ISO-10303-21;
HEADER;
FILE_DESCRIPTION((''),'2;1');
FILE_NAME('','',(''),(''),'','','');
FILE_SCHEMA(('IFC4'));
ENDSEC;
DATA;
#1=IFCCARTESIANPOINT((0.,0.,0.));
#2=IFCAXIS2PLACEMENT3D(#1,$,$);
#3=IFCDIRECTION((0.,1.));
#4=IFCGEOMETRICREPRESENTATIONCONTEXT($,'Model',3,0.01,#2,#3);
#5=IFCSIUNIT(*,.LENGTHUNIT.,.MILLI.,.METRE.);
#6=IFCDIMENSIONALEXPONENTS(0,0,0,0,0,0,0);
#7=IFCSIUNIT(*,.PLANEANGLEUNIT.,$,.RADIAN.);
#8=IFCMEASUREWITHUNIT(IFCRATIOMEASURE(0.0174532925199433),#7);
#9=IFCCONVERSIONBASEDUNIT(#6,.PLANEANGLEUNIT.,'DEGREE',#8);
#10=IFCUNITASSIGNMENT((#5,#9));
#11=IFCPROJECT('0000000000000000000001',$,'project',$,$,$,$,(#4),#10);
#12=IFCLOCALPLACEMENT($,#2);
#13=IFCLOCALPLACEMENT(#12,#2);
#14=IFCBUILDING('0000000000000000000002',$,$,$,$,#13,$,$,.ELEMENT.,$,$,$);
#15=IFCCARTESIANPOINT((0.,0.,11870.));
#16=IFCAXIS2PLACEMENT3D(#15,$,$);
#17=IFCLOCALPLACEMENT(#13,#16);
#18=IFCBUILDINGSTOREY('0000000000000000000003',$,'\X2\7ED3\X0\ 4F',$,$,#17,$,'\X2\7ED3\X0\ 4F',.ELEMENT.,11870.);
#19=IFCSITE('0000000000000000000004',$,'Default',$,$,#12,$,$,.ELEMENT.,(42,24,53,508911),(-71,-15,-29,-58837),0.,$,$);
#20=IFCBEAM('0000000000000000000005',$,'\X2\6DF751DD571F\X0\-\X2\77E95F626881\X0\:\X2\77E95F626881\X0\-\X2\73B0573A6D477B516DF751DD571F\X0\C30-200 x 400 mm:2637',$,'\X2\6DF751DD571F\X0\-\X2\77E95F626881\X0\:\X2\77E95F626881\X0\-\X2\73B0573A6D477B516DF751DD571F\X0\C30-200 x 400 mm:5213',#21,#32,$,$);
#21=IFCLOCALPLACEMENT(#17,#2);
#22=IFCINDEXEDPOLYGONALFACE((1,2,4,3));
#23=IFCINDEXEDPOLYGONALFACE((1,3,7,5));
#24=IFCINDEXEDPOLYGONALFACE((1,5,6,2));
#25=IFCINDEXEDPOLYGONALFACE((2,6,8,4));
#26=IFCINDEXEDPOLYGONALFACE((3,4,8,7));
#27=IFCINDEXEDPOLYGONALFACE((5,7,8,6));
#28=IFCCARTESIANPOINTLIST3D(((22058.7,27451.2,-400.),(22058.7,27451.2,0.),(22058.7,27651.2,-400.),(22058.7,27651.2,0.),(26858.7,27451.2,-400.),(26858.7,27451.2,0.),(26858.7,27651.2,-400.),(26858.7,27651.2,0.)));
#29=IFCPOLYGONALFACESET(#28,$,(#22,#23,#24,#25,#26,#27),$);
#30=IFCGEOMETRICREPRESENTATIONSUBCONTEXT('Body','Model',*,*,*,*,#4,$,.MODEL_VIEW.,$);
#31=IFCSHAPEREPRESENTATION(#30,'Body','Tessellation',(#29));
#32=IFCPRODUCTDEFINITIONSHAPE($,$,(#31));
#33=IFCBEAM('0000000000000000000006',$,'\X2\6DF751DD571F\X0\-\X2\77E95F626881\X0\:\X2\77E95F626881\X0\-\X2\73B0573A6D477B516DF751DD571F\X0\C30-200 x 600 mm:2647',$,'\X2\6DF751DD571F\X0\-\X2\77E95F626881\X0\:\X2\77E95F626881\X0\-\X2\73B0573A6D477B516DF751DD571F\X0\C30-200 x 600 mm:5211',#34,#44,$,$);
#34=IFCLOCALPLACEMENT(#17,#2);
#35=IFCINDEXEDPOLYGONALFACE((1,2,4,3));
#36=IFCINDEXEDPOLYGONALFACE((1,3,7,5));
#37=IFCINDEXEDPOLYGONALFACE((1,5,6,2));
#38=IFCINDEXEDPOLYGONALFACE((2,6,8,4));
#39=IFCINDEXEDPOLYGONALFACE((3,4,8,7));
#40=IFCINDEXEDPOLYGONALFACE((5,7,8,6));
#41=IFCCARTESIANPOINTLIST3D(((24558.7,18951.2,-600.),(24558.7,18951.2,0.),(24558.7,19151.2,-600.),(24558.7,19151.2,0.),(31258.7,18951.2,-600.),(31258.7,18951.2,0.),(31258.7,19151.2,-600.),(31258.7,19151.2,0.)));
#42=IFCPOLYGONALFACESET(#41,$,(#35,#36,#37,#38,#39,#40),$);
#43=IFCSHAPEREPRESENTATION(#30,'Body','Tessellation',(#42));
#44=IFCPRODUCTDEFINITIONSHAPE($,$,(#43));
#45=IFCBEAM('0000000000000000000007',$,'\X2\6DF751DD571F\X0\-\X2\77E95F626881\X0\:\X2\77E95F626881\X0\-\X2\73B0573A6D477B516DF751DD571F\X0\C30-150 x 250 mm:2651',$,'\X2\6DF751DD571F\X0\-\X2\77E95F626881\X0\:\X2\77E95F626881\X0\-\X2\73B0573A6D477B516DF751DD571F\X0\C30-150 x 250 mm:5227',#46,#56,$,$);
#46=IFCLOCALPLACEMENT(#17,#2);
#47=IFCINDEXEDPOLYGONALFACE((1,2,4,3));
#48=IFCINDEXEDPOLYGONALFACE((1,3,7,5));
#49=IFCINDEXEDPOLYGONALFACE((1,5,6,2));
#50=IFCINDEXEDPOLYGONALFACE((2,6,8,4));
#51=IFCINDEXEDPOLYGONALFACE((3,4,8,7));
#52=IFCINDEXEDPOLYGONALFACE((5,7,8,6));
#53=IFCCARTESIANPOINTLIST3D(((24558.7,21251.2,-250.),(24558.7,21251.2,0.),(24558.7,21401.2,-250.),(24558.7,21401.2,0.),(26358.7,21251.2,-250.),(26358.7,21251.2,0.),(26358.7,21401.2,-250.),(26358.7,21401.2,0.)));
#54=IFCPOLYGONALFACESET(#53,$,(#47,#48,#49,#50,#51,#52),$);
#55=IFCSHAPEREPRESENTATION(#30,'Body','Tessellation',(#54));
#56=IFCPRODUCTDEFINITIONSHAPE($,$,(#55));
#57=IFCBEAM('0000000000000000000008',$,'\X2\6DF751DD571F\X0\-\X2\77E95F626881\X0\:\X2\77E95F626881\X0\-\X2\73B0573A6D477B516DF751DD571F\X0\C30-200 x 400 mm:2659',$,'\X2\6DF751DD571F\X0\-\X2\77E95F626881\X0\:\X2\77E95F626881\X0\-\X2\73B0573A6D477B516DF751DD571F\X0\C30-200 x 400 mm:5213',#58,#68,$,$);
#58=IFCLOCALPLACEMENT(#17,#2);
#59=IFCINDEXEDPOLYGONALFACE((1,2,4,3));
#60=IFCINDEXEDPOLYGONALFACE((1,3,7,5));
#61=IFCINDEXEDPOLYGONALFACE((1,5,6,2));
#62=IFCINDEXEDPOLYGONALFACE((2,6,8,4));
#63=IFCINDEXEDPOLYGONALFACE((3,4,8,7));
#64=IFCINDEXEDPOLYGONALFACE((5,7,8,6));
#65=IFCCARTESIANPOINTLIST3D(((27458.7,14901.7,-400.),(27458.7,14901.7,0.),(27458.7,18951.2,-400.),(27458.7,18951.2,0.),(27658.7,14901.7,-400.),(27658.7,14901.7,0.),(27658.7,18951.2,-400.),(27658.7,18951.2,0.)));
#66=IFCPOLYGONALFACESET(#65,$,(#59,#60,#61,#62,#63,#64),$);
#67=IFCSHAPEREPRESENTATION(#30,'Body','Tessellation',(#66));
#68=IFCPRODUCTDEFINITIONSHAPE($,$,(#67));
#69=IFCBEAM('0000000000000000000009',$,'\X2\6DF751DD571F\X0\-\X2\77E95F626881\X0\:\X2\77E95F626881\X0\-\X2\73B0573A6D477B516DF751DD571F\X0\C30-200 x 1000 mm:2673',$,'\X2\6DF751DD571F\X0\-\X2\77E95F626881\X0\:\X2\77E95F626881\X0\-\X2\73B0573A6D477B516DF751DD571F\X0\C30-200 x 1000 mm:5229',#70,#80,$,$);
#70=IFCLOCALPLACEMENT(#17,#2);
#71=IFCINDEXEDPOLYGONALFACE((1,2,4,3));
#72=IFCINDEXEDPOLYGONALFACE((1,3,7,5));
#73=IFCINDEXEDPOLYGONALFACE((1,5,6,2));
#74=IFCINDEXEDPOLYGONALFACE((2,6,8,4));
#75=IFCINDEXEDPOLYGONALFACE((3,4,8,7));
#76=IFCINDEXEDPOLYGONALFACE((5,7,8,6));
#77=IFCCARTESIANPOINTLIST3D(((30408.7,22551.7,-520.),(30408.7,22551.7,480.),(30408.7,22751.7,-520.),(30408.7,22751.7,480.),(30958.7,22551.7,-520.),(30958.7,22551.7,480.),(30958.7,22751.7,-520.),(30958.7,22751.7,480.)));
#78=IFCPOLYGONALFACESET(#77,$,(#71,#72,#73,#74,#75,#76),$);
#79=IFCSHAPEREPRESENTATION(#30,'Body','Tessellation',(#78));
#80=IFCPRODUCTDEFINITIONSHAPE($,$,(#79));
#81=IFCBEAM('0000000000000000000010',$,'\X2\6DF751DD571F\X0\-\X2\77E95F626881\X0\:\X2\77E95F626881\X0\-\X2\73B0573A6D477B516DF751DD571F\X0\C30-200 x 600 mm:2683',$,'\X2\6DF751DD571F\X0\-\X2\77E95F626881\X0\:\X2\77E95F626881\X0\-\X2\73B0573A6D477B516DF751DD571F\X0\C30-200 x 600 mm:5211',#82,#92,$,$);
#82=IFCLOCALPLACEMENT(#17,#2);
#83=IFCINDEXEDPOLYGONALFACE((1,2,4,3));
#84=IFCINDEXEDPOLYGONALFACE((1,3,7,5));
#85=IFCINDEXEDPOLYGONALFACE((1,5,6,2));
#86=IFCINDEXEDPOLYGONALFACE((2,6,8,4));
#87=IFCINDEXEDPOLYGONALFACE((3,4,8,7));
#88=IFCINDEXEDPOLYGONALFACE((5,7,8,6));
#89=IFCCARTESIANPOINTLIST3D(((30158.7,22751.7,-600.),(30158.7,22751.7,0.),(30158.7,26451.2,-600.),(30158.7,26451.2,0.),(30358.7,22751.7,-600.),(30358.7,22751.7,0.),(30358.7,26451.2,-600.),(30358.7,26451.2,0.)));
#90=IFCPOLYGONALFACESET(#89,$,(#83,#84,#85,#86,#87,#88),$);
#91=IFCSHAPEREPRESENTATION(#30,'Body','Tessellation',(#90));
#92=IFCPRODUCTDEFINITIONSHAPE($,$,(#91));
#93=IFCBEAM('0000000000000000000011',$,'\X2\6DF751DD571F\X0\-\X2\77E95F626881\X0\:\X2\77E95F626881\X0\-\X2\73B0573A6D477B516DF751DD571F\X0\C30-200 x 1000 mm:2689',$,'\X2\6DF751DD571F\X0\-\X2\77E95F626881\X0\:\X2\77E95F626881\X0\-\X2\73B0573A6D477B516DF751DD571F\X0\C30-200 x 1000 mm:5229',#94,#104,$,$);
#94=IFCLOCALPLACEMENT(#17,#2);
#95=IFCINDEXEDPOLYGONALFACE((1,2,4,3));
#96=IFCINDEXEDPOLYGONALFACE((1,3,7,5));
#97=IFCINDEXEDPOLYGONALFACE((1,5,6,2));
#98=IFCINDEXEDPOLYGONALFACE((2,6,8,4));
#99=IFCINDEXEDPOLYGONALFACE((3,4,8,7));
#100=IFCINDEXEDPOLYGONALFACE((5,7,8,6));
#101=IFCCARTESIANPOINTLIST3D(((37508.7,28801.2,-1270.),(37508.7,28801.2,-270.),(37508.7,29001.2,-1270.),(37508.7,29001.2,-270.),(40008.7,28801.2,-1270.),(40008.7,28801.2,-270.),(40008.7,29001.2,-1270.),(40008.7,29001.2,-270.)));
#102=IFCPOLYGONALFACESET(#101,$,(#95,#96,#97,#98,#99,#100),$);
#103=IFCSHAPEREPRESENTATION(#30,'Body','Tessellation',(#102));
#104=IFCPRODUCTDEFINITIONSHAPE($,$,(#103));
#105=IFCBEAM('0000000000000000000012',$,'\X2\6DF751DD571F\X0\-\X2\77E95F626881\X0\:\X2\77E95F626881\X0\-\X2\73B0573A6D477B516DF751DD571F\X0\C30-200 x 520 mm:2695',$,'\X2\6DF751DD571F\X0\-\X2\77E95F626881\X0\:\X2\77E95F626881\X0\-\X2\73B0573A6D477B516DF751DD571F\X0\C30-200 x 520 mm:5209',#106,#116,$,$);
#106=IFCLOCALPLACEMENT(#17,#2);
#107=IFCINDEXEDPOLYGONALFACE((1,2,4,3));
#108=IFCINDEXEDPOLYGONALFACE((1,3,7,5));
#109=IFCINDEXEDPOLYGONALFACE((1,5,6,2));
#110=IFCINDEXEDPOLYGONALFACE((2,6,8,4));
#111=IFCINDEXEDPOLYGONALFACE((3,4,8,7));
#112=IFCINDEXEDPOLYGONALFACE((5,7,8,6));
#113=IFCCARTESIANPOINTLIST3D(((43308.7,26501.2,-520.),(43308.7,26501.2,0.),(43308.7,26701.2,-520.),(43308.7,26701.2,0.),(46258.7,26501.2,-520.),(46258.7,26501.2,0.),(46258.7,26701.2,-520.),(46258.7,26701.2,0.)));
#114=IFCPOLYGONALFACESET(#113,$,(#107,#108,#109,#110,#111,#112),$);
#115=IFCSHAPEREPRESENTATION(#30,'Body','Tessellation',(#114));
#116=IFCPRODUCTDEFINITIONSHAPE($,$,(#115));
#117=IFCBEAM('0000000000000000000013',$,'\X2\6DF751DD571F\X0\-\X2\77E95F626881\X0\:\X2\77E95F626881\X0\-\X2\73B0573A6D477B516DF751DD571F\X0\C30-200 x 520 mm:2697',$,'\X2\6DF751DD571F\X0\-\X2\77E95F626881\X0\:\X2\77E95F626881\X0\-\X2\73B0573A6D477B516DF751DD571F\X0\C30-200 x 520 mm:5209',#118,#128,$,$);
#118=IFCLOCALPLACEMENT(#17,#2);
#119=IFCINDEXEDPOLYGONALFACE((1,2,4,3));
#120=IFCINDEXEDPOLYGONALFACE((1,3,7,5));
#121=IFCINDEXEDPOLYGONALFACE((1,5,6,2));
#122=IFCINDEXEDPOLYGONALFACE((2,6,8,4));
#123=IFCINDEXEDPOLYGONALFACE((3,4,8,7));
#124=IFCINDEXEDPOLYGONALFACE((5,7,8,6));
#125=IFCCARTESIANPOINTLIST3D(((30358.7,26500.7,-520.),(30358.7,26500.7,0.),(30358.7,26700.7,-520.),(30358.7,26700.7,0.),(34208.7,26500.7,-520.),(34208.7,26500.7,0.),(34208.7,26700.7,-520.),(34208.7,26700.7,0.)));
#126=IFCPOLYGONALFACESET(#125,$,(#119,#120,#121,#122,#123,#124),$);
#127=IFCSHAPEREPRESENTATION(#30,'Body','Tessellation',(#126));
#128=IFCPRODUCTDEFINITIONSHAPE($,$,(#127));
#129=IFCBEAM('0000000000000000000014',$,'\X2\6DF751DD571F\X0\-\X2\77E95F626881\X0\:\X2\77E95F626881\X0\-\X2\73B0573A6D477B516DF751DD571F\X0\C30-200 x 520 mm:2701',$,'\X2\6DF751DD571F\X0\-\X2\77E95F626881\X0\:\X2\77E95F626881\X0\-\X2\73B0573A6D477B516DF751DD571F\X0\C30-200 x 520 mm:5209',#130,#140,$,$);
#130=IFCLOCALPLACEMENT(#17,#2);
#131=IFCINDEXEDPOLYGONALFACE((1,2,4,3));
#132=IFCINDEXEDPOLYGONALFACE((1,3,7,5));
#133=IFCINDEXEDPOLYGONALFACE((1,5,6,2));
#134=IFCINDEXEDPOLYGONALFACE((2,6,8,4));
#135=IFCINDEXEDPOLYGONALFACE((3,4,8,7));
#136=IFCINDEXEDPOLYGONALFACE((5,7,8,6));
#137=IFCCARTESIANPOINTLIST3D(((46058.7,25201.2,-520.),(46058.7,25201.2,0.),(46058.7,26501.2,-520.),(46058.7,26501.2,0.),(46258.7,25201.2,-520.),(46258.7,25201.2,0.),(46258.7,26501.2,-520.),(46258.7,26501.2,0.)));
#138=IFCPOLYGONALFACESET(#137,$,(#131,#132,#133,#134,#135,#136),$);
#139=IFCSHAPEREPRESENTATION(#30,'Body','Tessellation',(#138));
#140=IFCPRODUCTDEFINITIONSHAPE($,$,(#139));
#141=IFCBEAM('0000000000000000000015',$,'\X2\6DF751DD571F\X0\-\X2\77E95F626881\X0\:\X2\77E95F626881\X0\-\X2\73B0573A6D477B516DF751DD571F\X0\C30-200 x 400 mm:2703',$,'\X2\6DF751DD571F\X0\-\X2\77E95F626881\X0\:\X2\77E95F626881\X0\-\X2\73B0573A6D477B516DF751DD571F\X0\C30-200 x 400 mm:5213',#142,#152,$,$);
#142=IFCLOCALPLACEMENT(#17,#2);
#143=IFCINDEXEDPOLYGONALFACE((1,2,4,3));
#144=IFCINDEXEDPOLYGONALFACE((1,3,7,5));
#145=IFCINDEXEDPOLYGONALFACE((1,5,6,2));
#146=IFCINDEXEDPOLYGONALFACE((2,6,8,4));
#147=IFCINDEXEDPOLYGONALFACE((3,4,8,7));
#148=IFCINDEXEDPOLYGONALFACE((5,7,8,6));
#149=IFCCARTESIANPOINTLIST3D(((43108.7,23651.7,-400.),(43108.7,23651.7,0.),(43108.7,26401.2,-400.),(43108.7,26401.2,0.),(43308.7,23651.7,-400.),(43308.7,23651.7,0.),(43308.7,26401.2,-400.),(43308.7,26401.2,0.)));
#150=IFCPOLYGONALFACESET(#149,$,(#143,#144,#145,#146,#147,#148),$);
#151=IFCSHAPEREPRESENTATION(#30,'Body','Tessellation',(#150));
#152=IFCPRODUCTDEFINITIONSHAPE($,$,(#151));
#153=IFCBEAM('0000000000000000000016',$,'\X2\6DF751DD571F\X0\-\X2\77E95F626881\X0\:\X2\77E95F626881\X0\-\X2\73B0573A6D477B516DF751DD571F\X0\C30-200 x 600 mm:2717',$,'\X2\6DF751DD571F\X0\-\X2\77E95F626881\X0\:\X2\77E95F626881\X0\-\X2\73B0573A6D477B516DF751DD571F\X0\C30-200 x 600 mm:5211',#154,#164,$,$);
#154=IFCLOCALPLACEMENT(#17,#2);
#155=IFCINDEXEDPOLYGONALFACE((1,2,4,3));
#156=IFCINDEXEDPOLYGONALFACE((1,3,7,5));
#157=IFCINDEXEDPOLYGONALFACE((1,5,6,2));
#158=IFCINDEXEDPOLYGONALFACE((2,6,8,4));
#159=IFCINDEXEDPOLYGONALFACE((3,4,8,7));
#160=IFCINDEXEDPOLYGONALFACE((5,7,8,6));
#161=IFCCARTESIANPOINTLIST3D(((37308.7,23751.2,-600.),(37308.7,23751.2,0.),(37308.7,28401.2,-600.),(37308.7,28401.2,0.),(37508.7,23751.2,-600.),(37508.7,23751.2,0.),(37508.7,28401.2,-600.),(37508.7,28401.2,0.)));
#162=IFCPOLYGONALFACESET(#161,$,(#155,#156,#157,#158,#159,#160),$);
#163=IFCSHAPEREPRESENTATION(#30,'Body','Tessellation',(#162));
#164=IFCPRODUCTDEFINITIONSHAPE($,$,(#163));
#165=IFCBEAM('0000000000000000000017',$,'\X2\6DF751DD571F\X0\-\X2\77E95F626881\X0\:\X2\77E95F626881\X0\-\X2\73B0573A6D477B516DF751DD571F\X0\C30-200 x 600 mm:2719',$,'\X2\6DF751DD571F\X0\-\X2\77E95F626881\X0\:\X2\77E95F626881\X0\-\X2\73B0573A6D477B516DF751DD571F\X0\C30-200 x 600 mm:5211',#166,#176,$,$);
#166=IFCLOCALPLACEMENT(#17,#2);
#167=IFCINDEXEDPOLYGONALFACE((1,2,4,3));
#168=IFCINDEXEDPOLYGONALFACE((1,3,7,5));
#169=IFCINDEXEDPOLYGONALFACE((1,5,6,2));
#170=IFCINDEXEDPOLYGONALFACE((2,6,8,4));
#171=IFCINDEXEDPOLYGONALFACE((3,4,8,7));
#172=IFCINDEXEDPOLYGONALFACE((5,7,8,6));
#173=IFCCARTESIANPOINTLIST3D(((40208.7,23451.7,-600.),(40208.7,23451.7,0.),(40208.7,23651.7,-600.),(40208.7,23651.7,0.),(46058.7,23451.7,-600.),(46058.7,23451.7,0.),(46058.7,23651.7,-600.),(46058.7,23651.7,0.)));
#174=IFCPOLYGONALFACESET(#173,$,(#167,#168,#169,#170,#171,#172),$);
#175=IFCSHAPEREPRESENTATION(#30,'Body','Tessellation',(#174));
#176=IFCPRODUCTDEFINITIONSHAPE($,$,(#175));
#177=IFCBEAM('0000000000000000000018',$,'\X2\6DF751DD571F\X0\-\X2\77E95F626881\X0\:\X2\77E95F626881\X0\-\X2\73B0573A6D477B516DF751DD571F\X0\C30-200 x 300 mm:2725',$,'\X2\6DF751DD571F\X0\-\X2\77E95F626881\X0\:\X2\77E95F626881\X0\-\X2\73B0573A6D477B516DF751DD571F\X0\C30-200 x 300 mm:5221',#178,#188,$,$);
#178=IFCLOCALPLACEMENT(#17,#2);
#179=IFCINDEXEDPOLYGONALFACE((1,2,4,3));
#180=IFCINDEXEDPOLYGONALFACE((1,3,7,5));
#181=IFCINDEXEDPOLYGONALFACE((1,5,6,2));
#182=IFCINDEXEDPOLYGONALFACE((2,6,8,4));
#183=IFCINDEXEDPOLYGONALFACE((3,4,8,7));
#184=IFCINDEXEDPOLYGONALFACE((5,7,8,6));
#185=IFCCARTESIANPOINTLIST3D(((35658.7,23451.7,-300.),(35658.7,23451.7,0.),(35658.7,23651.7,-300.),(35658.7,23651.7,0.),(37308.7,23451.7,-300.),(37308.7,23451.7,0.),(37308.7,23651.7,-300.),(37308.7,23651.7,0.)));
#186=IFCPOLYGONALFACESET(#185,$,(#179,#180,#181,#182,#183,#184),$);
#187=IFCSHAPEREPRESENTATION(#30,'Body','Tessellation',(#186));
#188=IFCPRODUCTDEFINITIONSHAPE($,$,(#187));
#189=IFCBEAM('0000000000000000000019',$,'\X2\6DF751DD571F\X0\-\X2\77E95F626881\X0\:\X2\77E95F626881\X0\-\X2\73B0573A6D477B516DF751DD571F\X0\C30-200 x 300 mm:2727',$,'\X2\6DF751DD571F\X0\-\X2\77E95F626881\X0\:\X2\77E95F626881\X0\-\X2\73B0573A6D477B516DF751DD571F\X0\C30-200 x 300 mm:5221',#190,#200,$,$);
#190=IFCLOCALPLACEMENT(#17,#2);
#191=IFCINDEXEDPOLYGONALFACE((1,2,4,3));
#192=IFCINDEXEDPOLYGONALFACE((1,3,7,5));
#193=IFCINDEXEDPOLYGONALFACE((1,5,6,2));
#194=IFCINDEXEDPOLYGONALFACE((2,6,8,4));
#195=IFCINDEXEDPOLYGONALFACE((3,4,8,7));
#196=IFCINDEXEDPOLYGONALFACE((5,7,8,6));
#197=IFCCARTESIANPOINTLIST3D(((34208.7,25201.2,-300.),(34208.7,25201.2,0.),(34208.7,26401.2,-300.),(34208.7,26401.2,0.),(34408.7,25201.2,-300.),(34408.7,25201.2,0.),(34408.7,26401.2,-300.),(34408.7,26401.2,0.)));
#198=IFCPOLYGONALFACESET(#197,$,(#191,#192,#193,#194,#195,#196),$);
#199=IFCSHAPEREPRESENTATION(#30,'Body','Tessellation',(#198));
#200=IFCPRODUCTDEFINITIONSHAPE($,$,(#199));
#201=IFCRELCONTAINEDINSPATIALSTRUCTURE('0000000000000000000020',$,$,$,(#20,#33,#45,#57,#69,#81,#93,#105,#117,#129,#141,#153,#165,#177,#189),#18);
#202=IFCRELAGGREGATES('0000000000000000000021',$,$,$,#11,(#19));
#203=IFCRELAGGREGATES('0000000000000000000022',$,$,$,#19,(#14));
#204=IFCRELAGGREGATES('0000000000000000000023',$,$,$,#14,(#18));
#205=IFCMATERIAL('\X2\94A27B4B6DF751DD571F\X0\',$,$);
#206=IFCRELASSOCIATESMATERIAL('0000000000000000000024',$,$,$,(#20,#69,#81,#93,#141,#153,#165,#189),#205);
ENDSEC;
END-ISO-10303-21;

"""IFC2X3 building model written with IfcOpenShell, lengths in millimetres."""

from ifc_helpers import new_model, entity, si_unit, converted_unit, direction, frame, frame_2d, origin, origin_2d_with_axis, place, context, subcontext, project, spatial, rectangle, extrude, material, element, save


model = new_model("IFC2X3")

# Units and contexts
model_context = context("Model", 3, precision=0.01, world=origin(), true_north=direction((0.0, 1.0)))
body_context = subcontext(model_context, "Body", "Model", "MODEL_VIEW")
ifc_project = project(units=[si_unit("LENGTHUNIT", "METRE", prefix="MILLI"), converted_unit("PLANEANGLEUNIT", "DEGREE", entity("IfcRatioMeasure", 0.0174532925199433), si_unit("PLANEANGLEUNIT", "RADIAN"), dimensions=[0, 0, 0, 0, 0, 0, 0])], contexts=[model_context])

# Site, building, storey
site_placement = place(None, origin())
site = spatial("IfcSite", under=ifc_project, at=site_placement, Name="Default", CompositionType="ELEMENT", RefLatitude=(42, 24, 53, 508911), RefLongitude=(-71, -15, -29, -58837), RefElevation=0.0)
building_placement = place(site_placement, origin())
building = spatial("IfcBuilding", under=site, at=building_placement, CompositionType="ELEMENT")
storey_placement = place(building_placement, frame((0.0, 0.0, 11870.0)))
storey = spatial("IfcBuildingStorey", under=building, at=storey_placement, Name="结 4F", LongName="结 4F", CompositionType="ELEMENT", Elevation=11870.0)

# Beams
ifc_material = material(Name="钢筋混凝土")
beam_1_placement = place(storey_placement, frame((26958.7, 27551.2, 0.0), z_axis=(0.0, 0.0, 1.0), x_axis=(-1.0, 0.0, 0.0)))
element("IfcBeam", 1, at=beam_1_placement, inside=storey, material=ifc_material, Name="混凝土-矩形梁:矩形梁-现场浇筑混凝土C30-200 x 400 mm:2637", ObjectType="混凝土-矩形梁:矩形梁-现场浇筑混凝土C30-200 x 400 mm:5213", context=body_context, shape_type="SweptSolid", body=[
    extrude(rectangle(XDim=400.0, YDim=200.0, at=frame_2d((0.0, 0.0), x_axis=(1.0, 0.0))), frame((100.0, 0.0, -200.0), z_axis=(1.0, 0.0, 0.0), x_axis=(0.0, 0.0, -1.0)), (0.0, 0.0, 1.0), 4800.0),
])
beam_2_placement = place(storey_placement, frame((31358.7, 19051.2, 0.0), z_axis=(0.0, 0.0, 1.0), x_axis=(-1.0, 0.0, 0.0)))
element("IfcBeam", 2, at=beam_2_placement, inside=storey, Name="混凝土-矩形梁:矩形梁-现场浇筑混凝土C30-200 x 600 mm:2647", ObjectType="混凝土-矩形梁:矩形梁-现场浇筑混凝土C30-200 x 600 mm:5211", context=body_context, shape_type="SweptSolid", body=[
    extrude(rectangle(XDim=600.0, YDim=200.0, at=frame_2d((0.0, 0.0), x_axis=(1.0, 0.0))), frame((100.0, 0.0, -300.0), z_axis=(1.0, 0.0, 0.0), x_axis=(0.0, 0.0, -1.0)), (0.0, 0.0, 1.0), 6700.0),
])
beam_3_placement = place(storey_placement, frame((26433.7, 21326.2, 0.0), z_axis=(0.0, 0.0, 1.0), x_axis=(-1.0, 0.0, 0.0)))
element("IfcBeam", 3, at=beam_3_placement, inside=storey, Name="混凝土-矩形梁:矩形梁-现场浇筑混凝土C30-150 x 250 mm:2651", ObjectType="混凝土-矩形梁:矩形梁-现场浇筑混凝土C30-150 x 250 mm:5227", context=body_context, shape_type="SweptSolid", body=[
    extrude(rectangle(XDim=250.0, YDim=150.0, at=frame_2d((0.0, 0.0), x_axis=(1.0, 0.0))), frame((75.0, 0.0, -125.0), z_axis=(1.0, 0.0, 0.0), x_axis=(0.0, 0.0, -1.0)), (0.0, 0.0, 1.0), 1800.0),
])
beam_4_placement = place(storey_placement, frame((27558.7, 14801.7, 0.0), z_axis=(0.0, 0.0, 1.0), x_axis=(0.0, 1.0, 0.0)))
element("IfcBeam", 4, at=beam_4_placement, inside=storey, Name="混凝土-矩形梁:矩形梁-现场浇筑混凝土C30-200 x 400 mm:2659", ObjectType="混凝土-矩形梁:矩形梁-现场浇筑混凝土C30-200 x 400 mm:5213", context=body_context, shape_type="SweptSolid", body=[
    extrude(rectangle(XDim=400.0, YDim=200.0, at=frame_2d((0.0, 0.0), x_axis=(1.0, 0.0))), frame((100.0, 0.0, -200.0), z_axis=(1.0, 0.0, 0.0), x_axis=(0.0, 0.0, -1.0)), (0.0, 0.0, 1.0), 4049.5),
])
beam_5_placement = place(storey_placement, frame((31358.7, 22651.7, 480.0), z_axis=(0.0, 0.0, 1.0), x_axis=(-1.0, 0.0, 0.0)))
element("IfcBeam", 5, at=beam_5_placement, inside=storey, material=ifc_material, Name="混凝土-矩形梁:矩形梁-现场浇筑混凝土C30-200 x 1000 mm:2673", ObjectType="混凝土-矩形梁:矩形梁-现场浇筑混凝土C30-200 x 1000 mm:5229", context=body_context, shape_type="SweptSolid", body=[
    extrude(rectangle(XDim=1000.0, YDim=200.0, at=frame_2d((0.0, 0.0), x_axis=(1.0, 0.0))), frame((400.0, 0.0, -500.0), z_axis=(1.0, 0.0, 0.0), x_axis=(0.0, 0.0, -1.0)), (0.0, 0.0, 1.0), 550.0),
])
beam_6_placement = place(storey_placement, frame((30258.7, 22651.7, 0.0), z_axis=(0.0, 0.0, 1.0), x_axis=(0.0, 1.0, 0.0)))
element("IfcBeam", 6, at=beam_6_placement, inside=storey, material=ifc_material, Name="混凝土-矩形梁:矩形梁-现场浇筑混凝土C30-200 x 600 mm:2683", ObjectType="混凝土-矩形梁:矩形梁-现场浇筑混凝土C30-200 x 600 mm:5211", context=body_context, shape_type="SweptSolid", body=[
    extrude(rectangle(XDim=600.0, YDim=200.0, at=frame_2d((0.0, 0.0), x_axis=(1.0, 0.0))), frame((100.0, 0.0, -300.0), z_axis=(1.0, 0.0, 0.0), x_axis=(0.0, 0.0, -1.0)), (0.0, 0.0, 1.0), 3699.5),
])
beam_7_placement = place(storey_placement, frame((36458.7, 28901.2, -270.0)))
element("IfcBeam", 7, at=beam_7_placement, inside=storey, material=ifc_material, Name="混凝土-矩形梁:矩形梁-现场浇筑混凝土C30-200 x 1000 mm:2689", ObjectType="混凝土-矩形梁:矩形梁-现场浇筑混凝土C30-200 x 1000 mm:5229", context=body_context, shape_type="SweptSolid", body=[
    extrude(rectangle(XDim=1000.0, YDim=200.0, at=frame_2d((0.0, 0.0), x_axis=(1.0, 0.0))), frame((1050.0, 0.0, -500.0), z_axis=(1.0, 0.0, 0.0), x_axis=(0.0, 0.0, -1.0)), (0.0, 0.0, 1.0), 2500.0),
])
beam_8_placement = place(storey_placement, frame((43208.7, 26601.2, 0.0)))
element("IfcBeam", 8, at=beam_8_placement, inside=storey, Name="混凝土-矩形梁:矩形梁-现场浇筑混凝土C30-200 x 520 mm:2695", ObjectType="混凝土-矩形梁:矩形梁-现场浇筑混凝土C30-200 x 520 mm:5209", context=body_context, shape_type="SweptSolid", body=[
    extrude(rectangle(XDim=520.0, YDim=200.0, at=frame_2d((0.0, 0.0), x_axis=(1.0, 0.0))), frame((100.0, 0.0, -260.0), z_axis=(1.0, 0.0, 0.0), x_axis=(0.0, 0.0, -1.0)), (0.0, 0.0, 1.0), 2950.0),
])
beam_9_placement = place(storey_placement, frame((34308.7, 26600.7, 0.0), z_axis=(0.0, 0.0, 1.0), x_axis=(-1.0, 0.0, 0.0)))
element("IfcBeam", 9, at=beam_9_placement, inside=storey, Name="混凝土-矩形梁:矩形梁-现场浇筑混凝土C30-200 x 520 mm:2697", ObjectType="混凝土-矩形梁:矩形梁-现场浇筑混凝土C30-200 x 520 mm:5209", context=body_context, shape_type="SweptSolid", body=[
    extrude(rectangle(XDim=520.0, YDim=200.0, at=frame_2d((0.0, 0.0), x_axis=(1.0, 0.0))), frame((100.0, 0.0, -260.0), z_axis=(1.0, 0.0, 0.0), x_axis=(0.0, 0.0, -1.0)), (0.0, 0.0, 1.0), 3850.0),
])
beam_10_placement = place(storey_placement, frame((46158.7, 26601.2, 0.0), z_axis=(0.0, 0.0, 1.0), x_axis=(0.0, -1.0, 0.0)))
element("IfcBeam", 10, at=beam_10_placement, inside=storey, Name="混凝土-矩形梁:矩形梁-现场浇筑混凝土C30-200 x 520 mm:2701", ObjectType="混凝土-矩形梁:矩形梁-现场浇筑混凝土C30-200 x 520 mm:5209", context=body_context, shape_type="SweptSolid", body=[
    extrude(rectangle(XDim=520.0, YDim=200.0, at=frame_2d((0.0, 0.0), x_axis=(1.0, 0.0))), frame((100.0, 0.0, -260.0), z_axis=(1.0, 0.0, 0.0), x_axis=(0.0, 0.0, -1.0)), (0.0, 0.0, 1.0), 1300.0),
])
beam_11_placement = place(storey_placement, frame((43208.7, 23551.7, 0.0), z_axis=(0.0, 0.0, 1.0), x_axis=(0.0, 1.0, 0.0)))
element("IfcBeam", 11, at=beam_11_placement, inside=storey, material=ifc_material, Name="混凝土-矩形梁:矩形梁-现场浇筑混凝土C30-200 x 400 mm:2703", ObjectType="混凝土-矩形梁:矩形梁-现场浇筑混凝土C30-200 x 400 mm:5213", context=body_context, shape_type="SweptSolid", body=[
    extrude(rectangle(XDim=400.0, YDim=200.0, at=origin_2d_with_axis()), frame((100.0, 0.0, -200.0), z_axis=(1.0, 0.0, 0.0), x_axis=(0.0, 0.0, -1.0)), (0.0, 0.0, 1.0), 2749.5),
])
beam_12_placement = place(storey_placement, frame((37408.7, 23551.2, 0.0), z_axis=(0.0, 0.0, 1.0), x_axis=(0.0, 1.0, 0.0)))
element("IfcBeam", 12, at=beam_12_placement, inside=storey, material=ifc_material, Name="混凝土-矩形梁:矩形梁-现场浇筑混凝土C30-200 x 600 mm:2717", ObjectType="混凝土-矩形梁:矩形梁-现场浇筑混凝土C30-200 x 600 mm:5211", context=body_context, shape_type="SweptSolid", body=[
    extrude(rectangle(XDim=600.0, YDim=200.0, at=frame_2d((0.0, 0.0), x_axis=(1.0, 0.0))), frame((200.0, 0.0, -300.0), z_axis=(1.0, 0.0, 0.0), x_axis=(0.0, 0.0, -1.0)), (0.0, 0.0, 1.0), 4650.0),
])
beam_13_placement = place(storey_placement, frame((40108.7, 23551.7, 0.0)))
element("IfcBeam", 13, at=beam_13_placement, inside=storey, material=ifc_material, Name="混凝土-矩形梁:矩形梁-现场浇筑混凝土C30-200 x 600 mm:2719", ObjectType="混凝土-矩形梁:矩形梁-现场浇筑混凝土C30-200 x 600 mm:5211", context=body_context, shape_type="SweptSolid", body=[
    extrude(rectangle(XDim=600.0, YDim=200.0, at=frame_2d((0.0, 0.0), x_axis=(1.0, 0.0))), frame((100.0, 0.0, -300.0), z_axis=(1.0, 0.0, 0.0), x_axis=(0.0, 0.0, -1.0)), (0.0, 0.0, 1.0), 5850.0),
])
beam_14_placement = place(storey_placement, frame((35558.7, 23551.7, 0.0)))
element("IfcBeam", 14, at=beam_14_placement, inside=storey, Name="混凝土-矩形梁:矩形梁-现场浇筑混凝土C30-200 x 300 mm:2725", ObjectType="混凝土-矩形梁:矩形梁-现场浇筑混凝土C30-200 x 300 mm:5221", context=body_context, shape_type="SweptSolid", body=[
    extrude(rectangle(XDim=300.0, YDim=200.0, at=frame_2d((0.0, 0.0), x_axis=(1.0, 0.0))), frame((100.0, 0.0, -150.0), z_axis=(1.0, 0.0, 0.0), x_axis=(0.0, 0.0, -1.0)), (0.0, 0.0, 1.0), 1650.0),
])
beam_15_placement = place(storey_placement, frame((34308.7, 25101.2, 0.0), z_axis=(0.0, 0.0, 1.0), x_axis=(0.0, 1.0, 0.0)))
element("IfcBeam", 15, at=beam_15_placement, inside=storey, material=ifc_material, Name="混凝土-矩形梁:矩形梁-现场浇筑混凝土C30-200 x 300 mm:2727", ObjectType="混凝土-矩形梁:矩形梁-现场浇筑混凝土C30-200 x 300 mm:5221", context=body_context, shape_type="SweptSolid", body=[
    extrude(rectangle(XDim=300.0, YDim=200.0, at=frame_2d((0.0, 0.0), x_axis=(1.0, 0.0))), frame((100.0, 0.0, -150.0), z_axis=(1.0, 0.0, 0.0), x_axis=(0.0, 0.0, -1.0)), (0.0, 0.0, 1.0), 1200.0),
])

save(model, "model.ifc")
